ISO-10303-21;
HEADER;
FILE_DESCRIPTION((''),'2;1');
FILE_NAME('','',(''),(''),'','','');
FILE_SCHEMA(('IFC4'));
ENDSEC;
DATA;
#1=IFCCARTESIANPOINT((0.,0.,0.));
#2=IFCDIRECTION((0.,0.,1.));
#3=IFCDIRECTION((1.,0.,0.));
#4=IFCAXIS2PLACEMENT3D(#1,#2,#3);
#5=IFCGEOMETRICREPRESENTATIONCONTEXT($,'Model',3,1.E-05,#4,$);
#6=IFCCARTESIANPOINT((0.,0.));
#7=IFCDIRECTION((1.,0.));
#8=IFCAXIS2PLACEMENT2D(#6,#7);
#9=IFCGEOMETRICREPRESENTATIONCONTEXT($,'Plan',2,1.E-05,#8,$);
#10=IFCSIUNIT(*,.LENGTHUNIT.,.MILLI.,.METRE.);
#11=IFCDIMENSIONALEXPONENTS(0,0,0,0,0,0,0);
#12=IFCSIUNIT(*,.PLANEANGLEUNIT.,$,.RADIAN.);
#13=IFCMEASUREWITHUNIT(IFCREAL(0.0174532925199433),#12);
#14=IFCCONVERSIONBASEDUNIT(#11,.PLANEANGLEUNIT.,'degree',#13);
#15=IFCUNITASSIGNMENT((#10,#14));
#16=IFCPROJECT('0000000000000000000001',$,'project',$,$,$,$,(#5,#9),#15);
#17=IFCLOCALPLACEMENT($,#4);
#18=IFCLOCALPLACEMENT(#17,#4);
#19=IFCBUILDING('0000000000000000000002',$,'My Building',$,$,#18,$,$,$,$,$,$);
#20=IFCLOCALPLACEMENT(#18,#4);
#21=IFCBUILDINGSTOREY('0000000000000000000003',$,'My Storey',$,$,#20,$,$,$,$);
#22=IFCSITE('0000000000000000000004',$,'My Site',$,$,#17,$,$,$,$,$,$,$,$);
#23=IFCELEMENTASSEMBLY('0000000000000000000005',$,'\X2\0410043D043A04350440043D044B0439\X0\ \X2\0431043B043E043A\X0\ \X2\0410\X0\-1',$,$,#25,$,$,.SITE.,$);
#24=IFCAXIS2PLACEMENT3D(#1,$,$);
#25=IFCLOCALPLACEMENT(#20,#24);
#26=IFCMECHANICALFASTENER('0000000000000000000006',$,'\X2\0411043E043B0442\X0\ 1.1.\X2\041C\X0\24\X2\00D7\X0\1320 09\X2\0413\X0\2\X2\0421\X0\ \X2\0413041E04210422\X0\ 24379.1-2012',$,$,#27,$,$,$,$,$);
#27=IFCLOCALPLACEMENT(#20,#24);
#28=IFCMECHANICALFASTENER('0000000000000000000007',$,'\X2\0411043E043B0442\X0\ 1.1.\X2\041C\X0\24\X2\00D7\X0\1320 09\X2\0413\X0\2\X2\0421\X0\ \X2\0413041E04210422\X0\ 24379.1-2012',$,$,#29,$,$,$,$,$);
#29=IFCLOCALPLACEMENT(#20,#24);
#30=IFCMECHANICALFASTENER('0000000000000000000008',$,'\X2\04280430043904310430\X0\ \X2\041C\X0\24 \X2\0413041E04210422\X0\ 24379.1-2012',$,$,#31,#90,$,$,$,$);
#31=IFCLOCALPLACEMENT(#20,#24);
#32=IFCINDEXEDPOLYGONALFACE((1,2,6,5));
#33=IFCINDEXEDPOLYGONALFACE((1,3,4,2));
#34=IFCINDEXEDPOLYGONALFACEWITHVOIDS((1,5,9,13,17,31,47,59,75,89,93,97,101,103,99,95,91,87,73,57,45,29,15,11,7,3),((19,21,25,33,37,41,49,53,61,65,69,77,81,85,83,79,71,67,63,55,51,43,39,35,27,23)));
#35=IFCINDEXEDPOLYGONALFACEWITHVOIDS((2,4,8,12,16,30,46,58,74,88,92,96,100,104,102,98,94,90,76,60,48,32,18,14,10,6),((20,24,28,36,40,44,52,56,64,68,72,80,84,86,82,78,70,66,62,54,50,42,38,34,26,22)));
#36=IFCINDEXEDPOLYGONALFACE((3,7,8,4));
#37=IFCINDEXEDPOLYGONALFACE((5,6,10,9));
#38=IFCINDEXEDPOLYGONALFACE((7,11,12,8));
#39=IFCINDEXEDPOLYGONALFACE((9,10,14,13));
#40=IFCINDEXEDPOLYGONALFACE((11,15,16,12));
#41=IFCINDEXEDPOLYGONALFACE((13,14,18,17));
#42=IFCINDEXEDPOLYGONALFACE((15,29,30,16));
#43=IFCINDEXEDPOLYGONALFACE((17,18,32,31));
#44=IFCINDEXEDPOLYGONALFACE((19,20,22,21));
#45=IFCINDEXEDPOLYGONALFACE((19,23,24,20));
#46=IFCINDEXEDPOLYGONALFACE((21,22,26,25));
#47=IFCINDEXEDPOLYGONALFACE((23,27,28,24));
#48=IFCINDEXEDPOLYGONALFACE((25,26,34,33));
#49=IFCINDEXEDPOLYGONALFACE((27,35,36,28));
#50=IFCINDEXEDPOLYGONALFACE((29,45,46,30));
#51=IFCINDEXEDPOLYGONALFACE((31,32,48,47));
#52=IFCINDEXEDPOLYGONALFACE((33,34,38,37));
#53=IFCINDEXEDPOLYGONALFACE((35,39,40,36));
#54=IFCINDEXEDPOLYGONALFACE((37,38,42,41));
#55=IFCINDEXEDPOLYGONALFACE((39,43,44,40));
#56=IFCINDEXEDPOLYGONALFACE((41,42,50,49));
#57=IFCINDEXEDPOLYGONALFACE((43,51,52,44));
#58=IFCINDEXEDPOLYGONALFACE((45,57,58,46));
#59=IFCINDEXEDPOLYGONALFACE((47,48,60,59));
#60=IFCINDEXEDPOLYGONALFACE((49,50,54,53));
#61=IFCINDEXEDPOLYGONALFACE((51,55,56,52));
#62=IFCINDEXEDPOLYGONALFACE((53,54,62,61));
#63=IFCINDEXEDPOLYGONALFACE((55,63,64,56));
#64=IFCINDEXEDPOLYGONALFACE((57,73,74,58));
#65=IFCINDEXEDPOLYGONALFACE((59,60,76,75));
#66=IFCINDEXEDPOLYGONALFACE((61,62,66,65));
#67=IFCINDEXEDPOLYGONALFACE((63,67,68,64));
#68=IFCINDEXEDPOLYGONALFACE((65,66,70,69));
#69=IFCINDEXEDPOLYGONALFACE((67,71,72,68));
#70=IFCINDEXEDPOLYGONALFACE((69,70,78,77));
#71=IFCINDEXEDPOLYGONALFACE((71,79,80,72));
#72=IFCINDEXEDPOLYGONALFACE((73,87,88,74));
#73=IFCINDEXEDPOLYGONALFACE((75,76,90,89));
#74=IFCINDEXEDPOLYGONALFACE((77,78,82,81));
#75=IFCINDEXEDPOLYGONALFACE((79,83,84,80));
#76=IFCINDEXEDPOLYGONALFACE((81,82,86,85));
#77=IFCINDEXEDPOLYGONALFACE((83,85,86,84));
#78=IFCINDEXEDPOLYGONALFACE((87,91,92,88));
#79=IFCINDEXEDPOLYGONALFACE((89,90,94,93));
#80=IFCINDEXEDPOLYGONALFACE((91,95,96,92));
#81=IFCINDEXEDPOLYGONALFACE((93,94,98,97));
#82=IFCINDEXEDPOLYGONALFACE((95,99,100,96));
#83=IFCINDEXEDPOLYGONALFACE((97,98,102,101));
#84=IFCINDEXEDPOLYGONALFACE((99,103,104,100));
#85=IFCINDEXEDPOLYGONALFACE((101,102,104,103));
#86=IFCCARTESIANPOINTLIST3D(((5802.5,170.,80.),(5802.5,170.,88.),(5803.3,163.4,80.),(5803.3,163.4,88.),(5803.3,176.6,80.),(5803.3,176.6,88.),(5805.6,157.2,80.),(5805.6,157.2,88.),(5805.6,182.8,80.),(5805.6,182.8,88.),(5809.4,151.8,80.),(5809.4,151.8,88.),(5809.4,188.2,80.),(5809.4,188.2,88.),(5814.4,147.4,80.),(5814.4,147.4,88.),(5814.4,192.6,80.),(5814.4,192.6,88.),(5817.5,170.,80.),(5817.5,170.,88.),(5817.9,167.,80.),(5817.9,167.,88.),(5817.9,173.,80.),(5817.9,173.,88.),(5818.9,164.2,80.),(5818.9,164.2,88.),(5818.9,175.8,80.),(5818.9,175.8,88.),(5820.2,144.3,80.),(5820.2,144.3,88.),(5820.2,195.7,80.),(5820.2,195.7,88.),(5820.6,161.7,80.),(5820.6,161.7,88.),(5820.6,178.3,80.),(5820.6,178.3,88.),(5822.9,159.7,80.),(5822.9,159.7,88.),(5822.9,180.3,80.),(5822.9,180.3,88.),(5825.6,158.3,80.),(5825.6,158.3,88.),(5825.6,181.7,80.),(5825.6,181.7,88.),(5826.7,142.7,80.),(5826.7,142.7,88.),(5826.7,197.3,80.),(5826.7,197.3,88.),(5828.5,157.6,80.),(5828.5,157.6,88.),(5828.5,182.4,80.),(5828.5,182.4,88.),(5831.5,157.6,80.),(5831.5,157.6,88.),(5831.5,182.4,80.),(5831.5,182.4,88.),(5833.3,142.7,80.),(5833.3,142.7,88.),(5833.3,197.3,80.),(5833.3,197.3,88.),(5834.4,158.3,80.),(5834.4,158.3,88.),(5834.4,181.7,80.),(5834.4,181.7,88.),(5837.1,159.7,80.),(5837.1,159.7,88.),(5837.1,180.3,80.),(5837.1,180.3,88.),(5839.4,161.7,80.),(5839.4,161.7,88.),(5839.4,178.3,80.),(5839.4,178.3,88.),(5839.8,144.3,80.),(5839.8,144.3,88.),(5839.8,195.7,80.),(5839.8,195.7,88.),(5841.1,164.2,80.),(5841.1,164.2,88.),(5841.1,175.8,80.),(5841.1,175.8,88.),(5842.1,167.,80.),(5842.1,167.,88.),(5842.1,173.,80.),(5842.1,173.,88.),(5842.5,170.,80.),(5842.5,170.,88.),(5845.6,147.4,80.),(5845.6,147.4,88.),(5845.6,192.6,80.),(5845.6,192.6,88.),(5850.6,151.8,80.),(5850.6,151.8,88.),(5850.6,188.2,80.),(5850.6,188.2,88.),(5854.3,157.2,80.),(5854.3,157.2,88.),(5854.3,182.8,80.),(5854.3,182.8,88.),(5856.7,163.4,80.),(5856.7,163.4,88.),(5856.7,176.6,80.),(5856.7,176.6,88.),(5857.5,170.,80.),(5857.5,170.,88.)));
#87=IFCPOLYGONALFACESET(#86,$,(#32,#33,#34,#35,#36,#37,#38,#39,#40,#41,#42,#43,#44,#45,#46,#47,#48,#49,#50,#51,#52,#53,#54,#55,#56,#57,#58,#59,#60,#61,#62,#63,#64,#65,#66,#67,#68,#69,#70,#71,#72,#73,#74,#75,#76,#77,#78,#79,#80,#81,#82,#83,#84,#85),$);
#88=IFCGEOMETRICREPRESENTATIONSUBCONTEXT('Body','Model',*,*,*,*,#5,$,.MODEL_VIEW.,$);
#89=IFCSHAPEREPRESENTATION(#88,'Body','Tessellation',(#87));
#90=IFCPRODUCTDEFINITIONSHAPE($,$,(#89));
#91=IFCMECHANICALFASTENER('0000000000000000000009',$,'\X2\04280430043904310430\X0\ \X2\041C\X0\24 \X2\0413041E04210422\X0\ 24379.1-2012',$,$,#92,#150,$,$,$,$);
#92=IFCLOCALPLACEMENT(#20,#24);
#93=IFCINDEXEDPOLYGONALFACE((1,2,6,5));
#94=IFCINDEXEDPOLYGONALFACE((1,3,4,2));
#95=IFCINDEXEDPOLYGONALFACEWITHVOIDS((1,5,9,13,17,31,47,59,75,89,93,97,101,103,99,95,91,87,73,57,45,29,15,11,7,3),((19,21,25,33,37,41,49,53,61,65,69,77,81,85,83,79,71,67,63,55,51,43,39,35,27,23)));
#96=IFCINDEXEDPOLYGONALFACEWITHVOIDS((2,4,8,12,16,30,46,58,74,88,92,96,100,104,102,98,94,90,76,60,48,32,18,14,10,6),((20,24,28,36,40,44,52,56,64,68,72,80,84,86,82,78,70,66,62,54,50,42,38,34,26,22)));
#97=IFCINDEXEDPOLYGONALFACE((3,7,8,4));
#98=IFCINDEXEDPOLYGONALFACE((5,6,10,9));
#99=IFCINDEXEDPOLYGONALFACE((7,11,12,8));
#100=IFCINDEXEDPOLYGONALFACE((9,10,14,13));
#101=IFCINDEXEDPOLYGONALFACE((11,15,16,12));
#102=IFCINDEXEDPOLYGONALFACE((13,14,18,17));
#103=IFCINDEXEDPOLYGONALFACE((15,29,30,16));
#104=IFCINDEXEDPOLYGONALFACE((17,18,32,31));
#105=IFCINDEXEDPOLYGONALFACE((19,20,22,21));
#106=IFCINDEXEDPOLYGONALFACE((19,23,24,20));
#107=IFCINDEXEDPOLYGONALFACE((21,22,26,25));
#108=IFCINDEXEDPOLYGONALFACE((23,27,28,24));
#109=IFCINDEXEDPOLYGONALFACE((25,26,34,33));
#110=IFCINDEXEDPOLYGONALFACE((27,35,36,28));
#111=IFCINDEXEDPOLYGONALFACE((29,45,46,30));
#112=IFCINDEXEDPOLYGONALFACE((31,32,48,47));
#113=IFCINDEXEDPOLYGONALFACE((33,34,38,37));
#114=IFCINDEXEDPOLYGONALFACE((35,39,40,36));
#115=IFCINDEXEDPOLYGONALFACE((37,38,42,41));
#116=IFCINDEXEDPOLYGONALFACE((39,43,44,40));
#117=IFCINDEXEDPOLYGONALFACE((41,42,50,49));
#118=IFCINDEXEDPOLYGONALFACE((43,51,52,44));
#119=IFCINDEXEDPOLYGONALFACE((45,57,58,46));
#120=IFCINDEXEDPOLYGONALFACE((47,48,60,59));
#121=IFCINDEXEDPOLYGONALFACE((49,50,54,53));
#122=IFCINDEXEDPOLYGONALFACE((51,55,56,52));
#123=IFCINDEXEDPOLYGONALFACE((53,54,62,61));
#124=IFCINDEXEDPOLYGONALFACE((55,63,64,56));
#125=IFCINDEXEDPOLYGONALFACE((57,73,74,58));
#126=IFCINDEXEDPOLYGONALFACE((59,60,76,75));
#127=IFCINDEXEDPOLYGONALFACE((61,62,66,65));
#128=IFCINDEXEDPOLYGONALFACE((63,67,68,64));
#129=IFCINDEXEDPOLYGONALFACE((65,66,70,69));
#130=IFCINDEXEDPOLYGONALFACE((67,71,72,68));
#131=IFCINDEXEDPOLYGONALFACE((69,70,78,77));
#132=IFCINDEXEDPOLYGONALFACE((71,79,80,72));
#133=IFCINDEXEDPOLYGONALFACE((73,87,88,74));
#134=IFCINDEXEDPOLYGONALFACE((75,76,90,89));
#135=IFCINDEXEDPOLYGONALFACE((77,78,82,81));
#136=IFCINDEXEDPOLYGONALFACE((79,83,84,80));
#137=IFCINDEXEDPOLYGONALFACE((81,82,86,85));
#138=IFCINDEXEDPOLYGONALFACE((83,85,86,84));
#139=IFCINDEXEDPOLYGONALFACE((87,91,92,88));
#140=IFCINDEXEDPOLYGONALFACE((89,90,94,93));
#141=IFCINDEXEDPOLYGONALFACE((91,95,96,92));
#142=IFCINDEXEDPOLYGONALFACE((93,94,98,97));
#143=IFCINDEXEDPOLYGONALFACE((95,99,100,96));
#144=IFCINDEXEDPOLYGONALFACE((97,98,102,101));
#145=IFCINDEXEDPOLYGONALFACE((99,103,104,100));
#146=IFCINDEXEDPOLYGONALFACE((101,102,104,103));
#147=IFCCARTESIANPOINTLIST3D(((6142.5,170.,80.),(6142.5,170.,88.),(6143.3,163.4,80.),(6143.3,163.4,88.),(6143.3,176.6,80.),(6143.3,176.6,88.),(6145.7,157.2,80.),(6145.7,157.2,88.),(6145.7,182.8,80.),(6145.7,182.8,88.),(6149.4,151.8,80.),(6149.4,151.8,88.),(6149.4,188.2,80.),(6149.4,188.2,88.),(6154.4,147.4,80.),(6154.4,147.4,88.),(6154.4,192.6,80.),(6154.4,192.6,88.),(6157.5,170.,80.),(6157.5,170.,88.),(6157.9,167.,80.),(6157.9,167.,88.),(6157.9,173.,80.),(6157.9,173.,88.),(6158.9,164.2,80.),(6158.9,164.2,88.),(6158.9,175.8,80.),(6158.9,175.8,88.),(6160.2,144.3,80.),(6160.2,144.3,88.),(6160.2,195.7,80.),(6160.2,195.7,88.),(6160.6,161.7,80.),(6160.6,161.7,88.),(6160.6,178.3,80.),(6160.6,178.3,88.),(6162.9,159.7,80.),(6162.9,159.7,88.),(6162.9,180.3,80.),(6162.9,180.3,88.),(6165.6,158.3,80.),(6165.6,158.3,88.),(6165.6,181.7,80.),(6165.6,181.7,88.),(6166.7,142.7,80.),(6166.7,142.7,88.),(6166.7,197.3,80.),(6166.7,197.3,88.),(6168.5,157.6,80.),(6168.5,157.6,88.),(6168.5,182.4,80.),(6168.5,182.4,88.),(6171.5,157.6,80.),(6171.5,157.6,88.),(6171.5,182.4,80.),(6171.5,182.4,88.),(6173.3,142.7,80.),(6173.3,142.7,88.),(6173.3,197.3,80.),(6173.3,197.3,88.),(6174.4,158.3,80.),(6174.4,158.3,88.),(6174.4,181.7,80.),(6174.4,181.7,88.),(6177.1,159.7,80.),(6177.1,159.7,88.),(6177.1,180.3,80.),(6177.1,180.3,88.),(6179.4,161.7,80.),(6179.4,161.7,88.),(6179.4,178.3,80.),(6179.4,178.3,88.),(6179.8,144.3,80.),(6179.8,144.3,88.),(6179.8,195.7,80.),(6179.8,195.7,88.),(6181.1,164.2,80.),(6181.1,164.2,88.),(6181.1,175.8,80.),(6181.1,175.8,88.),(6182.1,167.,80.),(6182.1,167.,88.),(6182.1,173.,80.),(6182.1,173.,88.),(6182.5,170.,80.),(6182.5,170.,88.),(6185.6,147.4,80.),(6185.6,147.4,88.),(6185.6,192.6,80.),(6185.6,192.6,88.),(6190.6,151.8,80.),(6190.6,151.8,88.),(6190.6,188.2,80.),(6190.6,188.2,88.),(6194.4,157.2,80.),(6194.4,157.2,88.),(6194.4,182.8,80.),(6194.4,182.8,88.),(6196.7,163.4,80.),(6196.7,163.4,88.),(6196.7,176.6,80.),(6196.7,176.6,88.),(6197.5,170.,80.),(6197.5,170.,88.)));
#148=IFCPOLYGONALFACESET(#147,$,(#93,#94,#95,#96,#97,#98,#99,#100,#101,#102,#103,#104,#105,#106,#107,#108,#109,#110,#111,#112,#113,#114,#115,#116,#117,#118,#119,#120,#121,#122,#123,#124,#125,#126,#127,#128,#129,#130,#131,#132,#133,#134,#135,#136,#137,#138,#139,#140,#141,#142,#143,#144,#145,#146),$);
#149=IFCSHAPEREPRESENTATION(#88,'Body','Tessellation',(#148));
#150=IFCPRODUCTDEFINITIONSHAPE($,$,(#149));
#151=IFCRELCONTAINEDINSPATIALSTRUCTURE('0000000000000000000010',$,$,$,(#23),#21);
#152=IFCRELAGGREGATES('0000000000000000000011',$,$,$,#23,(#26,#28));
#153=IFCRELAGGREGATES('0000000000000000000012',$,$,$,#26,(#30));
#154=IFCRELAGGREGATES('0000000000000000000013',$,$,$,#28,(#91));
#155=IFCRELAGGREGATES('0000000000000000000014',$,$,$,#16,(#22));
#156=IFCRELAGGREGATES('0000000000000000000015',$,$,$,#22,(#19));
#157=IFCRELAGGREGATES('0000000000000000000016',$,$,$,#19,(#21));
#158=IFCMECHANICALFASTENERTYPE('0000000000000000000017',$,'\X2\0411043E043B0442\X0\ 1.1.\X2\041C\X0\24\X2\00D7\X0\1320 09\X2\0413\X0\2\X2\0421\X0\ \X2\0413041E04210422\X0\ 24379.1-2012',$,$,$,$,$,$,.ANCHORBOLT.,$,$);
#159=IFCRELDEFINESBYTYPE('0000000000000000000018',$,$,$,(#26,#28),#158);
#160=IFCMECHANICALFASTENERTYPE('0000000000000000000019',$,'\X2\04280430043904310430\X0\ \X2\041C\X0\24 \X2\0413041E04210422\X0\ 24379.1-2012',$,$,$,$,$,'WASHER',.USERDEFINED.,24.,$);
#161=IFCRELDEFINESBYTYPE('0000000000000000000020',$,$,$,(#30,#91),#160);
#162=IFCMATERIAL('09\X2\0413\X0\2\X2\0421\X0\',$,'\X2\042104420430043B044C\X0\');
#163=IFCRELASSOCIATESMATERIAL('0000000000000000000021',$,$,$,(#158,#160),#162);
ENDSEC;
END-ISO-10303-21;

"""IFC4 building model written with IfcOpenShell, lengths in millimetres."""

from ifc_helpers import new_model, entity, si_unit, converted_unit, frame, origin_with_axes, origin_2d_with_axis, place, context, subcontext, project, spatial, polyline, outline, extrude, source, transform, mapped, material, type_object, type_shapes, element, aggregate, save


model = new_model("IFC4")

# Units and contexts
model_context = context("Model", 3, precision=1e-05, world=origin_with_axes())
plan_context = context("Plan", 2, precision=1e-05, world=origin_2d_with_axis())
body_context = subcontext(model_context, "Body", "Model", "MODEL_VIEW")
ifc_project = project(units=[si_unit("LENGTHUNIT", "METRE", prefix="MILLI"), converted_unit("PLANEANGLEUNIT", "degree", entity("IfcReal", 0.0174532925199433), si_unit("PLANEANGLEUNIT", "RADIAN"), dimensions=[0, 0, 0, 0, 0, 0, 0])], contexts=[model_context, plan_context])

# Site, building, storey
site_placement = place(None, origin_with_axes())
site = spatial("IfcSite", under=ifc_project, at=site_placement, Name="My Site")
building_placement = place(site_placement, origin_with_axes())
building = spatial("IfcBuilding", under=site, at=building_placement, Name="My Building")
storey_placement = place(building_placement, origin_with_axes())
storey = spatial("IfcBuildingStorey", under=building, at=storey_placement, Name="My Storey")

# Element assembly, mechanical fasteners
assembly_1_placement = place(storey_placement, frame((6000.0, 0.0, 0.0), z_axis=(0.0, 0.0, 1.0), x_axis=(1.0, 0.0, 0.0)))
assembly_1 = element("IfcElementAssembly", 1, at=assembly_1_placement, inside=storey, Name="Анкерный блок А-1", AssemblyPlace="SITE")
ifc_material_1 = material(Name="09Г2С", Category="Сталь")
mechanical_fastener_type_1 = type_object("IfcMechanicalFastenerType", Name="Болт 1.1.М24×1320 09Г2С ГОСТ 24379.1-2012", PredefinedType="ANCHORBOLT", material=ifc_material_1)
mechanical_fastener_1_placement = place(assembly_1_placement, frame((-170.0, 170.0, 0.0), z_axis=(0.0, 0.0, 1.0), x_axis=(-1.0, 0.0, 0.0)))
mechanical_fastener_1 = element("IfcMechanicalFastener", 2, at=mechanical_fastener_1_placement, type_object=mechanical_fastener_type_1, Name="Болт 1.1.М24×1320 09Г2С ГОСТ 24379.1-2012")
mechanical_fastener_2_placement = place(assembly_1_placement, frame((170.0, 170.0, 0.0), z_axis=(0.0, 0.0, 1.0), x_axis=(-1.0, 0.0, 0.0)))
mechanical_fastener_2 = element("IfcMechanicalFastener", 3, at=mechanical_fastener_2_placement, type_object=mechanical_fastener_type_1, Name="Болт 1.1.М24×1320 09Г2С ГОСТ 24379.1-2012")
aggregate(assembly_1, [mechanical_fastener_1, mechanical_fastener_2])

# Mechanical fasteners
mechanical_fastener_type_2 = type_object("IfcMechanicalFastenerType", Name="Шайба М24 ГОСТ 24379.1-2012", ElementType="WASHER", NominalDiameter=24.0, PredefinedType="USERDEFINED", material=ifc_material_1)
shared_shape_1 = source(origin_with_axes(), body_context, "Body", "SweptSolid", [
    extrude(outline(polyline([(27.5, 0.0), (26.7, 6.6), (24.4, 12.8), (20.6, 18.2), (15.6, 22.6), (9.8, 25.7), (3.3, 27.3), (-3.3, 27.3), (-9.8, 25.7), (-15.6, 22.6), (-20.6, 18.2), (-24.4, 12.8), (-26.7, 6.6), (-27.5, 0.0), (-26.7, -6.6), (-24.4, -12.8), (-20.6, -18.2), (-15.6, -22.6), (-9.8, -25.7), (-3.3, -27.3), (3.3, -27.3), (9.8, -25.7), (15.6, -22.6), (20.6, -18.2), (24.4, -12.8), (26.7, -6.6), (27.5, 0.0)]), holes=[polyline([(-4.4, -11.7), (-7.1, -10.3), (-9.4, -8.3), (-11.1, -5.8), (-12.1, -3.0), (-12.5, 0.0), (-12.1, 3.0), (-11.1, 5.8), (-9.4, 8.3), (-7.1, 10.3), (-4.4, 11.7), (-1.5, 12.4), (1.5, 12.4), (4.4, 11.7), (7.1, 10.3), (9.4, 8.3), (11.1, 5.8), (12.1, 3.0), (12.5, 0.0), (12.1, -3.0), (11.1, -5.8), (9.4, -8.3), (7.1, -10.3), (4.4, -11.7), (1.5, -12.4), (-1.5, -12.4), (-4.4, -11.7)])]), frame((0.0, 0.0, 0.0), z_axis=(0.0, 0.0, 1.0), x_axis=(0.120537, -0.992709, 0.0)), (0.0, 0.0, 1.0), 8.0),
])
type_shapes(mechanical_fastener_type_2, [shared_shape_1])
mechanical_fastener_3_placement = place(mechanical_fastener_1_placement, frame((0.0, 0.0, 80.0), z_axis=(0.0, 0.0, 1.0), x_axis=(1.0, 0.0, 0.0)))
mechanical_fastener_3 = element("IfcMechanicalFastener", 4, at=mechanical_fastener_3_placement, type_object=mechanical_fastener_type_2, Name="Шайба М24 ГОСТ 24379.1-2012", context=body_context, shape_type="MappedRepresentation", body=[
    mapped(shared_shape_1, transform((0.0, 0.0, 0.0), x_axis=(1.0, 0.0, 0.0), y_axis=(0.0, 1.0, 0.0), z_axis=(0.0, 0.0, 1.0), scale=1.0)),
])
aggregate(mechanical_fastener_1, [mechanical_fastener_3])
mechanical_fastener_4_placement = place(mechanical_fastener_2_placement, frame((0.0, 0.0, 80.0), z_axis=(0.0, 0.0, 1.0), x_axis=(1.0, 0.0, 0.0)))
mechanical_fastener_4 = element("IfcMechanicalFastener", 5, at=mechanical_fastener_4_placement, type_object=mechanical_fastener_type_2, Name="Шайба М24 ГОСТ 24379.1-2012", context=body_context, shape_type="MappedRepresentation", body=[
    mapped(shared_shape_1, transform((0.0, 0.0, 0.0), x_axis=(1.0, 0.0, 0.0), y_axis=(0.0, 1.0, 0.0), z_axis=(0.0, 0.0, 1.0), scale=1.0)),
])
aggregate(mechanical_fastener_2, [mechanical_fastener_4])

save(model, "model.ifc")
